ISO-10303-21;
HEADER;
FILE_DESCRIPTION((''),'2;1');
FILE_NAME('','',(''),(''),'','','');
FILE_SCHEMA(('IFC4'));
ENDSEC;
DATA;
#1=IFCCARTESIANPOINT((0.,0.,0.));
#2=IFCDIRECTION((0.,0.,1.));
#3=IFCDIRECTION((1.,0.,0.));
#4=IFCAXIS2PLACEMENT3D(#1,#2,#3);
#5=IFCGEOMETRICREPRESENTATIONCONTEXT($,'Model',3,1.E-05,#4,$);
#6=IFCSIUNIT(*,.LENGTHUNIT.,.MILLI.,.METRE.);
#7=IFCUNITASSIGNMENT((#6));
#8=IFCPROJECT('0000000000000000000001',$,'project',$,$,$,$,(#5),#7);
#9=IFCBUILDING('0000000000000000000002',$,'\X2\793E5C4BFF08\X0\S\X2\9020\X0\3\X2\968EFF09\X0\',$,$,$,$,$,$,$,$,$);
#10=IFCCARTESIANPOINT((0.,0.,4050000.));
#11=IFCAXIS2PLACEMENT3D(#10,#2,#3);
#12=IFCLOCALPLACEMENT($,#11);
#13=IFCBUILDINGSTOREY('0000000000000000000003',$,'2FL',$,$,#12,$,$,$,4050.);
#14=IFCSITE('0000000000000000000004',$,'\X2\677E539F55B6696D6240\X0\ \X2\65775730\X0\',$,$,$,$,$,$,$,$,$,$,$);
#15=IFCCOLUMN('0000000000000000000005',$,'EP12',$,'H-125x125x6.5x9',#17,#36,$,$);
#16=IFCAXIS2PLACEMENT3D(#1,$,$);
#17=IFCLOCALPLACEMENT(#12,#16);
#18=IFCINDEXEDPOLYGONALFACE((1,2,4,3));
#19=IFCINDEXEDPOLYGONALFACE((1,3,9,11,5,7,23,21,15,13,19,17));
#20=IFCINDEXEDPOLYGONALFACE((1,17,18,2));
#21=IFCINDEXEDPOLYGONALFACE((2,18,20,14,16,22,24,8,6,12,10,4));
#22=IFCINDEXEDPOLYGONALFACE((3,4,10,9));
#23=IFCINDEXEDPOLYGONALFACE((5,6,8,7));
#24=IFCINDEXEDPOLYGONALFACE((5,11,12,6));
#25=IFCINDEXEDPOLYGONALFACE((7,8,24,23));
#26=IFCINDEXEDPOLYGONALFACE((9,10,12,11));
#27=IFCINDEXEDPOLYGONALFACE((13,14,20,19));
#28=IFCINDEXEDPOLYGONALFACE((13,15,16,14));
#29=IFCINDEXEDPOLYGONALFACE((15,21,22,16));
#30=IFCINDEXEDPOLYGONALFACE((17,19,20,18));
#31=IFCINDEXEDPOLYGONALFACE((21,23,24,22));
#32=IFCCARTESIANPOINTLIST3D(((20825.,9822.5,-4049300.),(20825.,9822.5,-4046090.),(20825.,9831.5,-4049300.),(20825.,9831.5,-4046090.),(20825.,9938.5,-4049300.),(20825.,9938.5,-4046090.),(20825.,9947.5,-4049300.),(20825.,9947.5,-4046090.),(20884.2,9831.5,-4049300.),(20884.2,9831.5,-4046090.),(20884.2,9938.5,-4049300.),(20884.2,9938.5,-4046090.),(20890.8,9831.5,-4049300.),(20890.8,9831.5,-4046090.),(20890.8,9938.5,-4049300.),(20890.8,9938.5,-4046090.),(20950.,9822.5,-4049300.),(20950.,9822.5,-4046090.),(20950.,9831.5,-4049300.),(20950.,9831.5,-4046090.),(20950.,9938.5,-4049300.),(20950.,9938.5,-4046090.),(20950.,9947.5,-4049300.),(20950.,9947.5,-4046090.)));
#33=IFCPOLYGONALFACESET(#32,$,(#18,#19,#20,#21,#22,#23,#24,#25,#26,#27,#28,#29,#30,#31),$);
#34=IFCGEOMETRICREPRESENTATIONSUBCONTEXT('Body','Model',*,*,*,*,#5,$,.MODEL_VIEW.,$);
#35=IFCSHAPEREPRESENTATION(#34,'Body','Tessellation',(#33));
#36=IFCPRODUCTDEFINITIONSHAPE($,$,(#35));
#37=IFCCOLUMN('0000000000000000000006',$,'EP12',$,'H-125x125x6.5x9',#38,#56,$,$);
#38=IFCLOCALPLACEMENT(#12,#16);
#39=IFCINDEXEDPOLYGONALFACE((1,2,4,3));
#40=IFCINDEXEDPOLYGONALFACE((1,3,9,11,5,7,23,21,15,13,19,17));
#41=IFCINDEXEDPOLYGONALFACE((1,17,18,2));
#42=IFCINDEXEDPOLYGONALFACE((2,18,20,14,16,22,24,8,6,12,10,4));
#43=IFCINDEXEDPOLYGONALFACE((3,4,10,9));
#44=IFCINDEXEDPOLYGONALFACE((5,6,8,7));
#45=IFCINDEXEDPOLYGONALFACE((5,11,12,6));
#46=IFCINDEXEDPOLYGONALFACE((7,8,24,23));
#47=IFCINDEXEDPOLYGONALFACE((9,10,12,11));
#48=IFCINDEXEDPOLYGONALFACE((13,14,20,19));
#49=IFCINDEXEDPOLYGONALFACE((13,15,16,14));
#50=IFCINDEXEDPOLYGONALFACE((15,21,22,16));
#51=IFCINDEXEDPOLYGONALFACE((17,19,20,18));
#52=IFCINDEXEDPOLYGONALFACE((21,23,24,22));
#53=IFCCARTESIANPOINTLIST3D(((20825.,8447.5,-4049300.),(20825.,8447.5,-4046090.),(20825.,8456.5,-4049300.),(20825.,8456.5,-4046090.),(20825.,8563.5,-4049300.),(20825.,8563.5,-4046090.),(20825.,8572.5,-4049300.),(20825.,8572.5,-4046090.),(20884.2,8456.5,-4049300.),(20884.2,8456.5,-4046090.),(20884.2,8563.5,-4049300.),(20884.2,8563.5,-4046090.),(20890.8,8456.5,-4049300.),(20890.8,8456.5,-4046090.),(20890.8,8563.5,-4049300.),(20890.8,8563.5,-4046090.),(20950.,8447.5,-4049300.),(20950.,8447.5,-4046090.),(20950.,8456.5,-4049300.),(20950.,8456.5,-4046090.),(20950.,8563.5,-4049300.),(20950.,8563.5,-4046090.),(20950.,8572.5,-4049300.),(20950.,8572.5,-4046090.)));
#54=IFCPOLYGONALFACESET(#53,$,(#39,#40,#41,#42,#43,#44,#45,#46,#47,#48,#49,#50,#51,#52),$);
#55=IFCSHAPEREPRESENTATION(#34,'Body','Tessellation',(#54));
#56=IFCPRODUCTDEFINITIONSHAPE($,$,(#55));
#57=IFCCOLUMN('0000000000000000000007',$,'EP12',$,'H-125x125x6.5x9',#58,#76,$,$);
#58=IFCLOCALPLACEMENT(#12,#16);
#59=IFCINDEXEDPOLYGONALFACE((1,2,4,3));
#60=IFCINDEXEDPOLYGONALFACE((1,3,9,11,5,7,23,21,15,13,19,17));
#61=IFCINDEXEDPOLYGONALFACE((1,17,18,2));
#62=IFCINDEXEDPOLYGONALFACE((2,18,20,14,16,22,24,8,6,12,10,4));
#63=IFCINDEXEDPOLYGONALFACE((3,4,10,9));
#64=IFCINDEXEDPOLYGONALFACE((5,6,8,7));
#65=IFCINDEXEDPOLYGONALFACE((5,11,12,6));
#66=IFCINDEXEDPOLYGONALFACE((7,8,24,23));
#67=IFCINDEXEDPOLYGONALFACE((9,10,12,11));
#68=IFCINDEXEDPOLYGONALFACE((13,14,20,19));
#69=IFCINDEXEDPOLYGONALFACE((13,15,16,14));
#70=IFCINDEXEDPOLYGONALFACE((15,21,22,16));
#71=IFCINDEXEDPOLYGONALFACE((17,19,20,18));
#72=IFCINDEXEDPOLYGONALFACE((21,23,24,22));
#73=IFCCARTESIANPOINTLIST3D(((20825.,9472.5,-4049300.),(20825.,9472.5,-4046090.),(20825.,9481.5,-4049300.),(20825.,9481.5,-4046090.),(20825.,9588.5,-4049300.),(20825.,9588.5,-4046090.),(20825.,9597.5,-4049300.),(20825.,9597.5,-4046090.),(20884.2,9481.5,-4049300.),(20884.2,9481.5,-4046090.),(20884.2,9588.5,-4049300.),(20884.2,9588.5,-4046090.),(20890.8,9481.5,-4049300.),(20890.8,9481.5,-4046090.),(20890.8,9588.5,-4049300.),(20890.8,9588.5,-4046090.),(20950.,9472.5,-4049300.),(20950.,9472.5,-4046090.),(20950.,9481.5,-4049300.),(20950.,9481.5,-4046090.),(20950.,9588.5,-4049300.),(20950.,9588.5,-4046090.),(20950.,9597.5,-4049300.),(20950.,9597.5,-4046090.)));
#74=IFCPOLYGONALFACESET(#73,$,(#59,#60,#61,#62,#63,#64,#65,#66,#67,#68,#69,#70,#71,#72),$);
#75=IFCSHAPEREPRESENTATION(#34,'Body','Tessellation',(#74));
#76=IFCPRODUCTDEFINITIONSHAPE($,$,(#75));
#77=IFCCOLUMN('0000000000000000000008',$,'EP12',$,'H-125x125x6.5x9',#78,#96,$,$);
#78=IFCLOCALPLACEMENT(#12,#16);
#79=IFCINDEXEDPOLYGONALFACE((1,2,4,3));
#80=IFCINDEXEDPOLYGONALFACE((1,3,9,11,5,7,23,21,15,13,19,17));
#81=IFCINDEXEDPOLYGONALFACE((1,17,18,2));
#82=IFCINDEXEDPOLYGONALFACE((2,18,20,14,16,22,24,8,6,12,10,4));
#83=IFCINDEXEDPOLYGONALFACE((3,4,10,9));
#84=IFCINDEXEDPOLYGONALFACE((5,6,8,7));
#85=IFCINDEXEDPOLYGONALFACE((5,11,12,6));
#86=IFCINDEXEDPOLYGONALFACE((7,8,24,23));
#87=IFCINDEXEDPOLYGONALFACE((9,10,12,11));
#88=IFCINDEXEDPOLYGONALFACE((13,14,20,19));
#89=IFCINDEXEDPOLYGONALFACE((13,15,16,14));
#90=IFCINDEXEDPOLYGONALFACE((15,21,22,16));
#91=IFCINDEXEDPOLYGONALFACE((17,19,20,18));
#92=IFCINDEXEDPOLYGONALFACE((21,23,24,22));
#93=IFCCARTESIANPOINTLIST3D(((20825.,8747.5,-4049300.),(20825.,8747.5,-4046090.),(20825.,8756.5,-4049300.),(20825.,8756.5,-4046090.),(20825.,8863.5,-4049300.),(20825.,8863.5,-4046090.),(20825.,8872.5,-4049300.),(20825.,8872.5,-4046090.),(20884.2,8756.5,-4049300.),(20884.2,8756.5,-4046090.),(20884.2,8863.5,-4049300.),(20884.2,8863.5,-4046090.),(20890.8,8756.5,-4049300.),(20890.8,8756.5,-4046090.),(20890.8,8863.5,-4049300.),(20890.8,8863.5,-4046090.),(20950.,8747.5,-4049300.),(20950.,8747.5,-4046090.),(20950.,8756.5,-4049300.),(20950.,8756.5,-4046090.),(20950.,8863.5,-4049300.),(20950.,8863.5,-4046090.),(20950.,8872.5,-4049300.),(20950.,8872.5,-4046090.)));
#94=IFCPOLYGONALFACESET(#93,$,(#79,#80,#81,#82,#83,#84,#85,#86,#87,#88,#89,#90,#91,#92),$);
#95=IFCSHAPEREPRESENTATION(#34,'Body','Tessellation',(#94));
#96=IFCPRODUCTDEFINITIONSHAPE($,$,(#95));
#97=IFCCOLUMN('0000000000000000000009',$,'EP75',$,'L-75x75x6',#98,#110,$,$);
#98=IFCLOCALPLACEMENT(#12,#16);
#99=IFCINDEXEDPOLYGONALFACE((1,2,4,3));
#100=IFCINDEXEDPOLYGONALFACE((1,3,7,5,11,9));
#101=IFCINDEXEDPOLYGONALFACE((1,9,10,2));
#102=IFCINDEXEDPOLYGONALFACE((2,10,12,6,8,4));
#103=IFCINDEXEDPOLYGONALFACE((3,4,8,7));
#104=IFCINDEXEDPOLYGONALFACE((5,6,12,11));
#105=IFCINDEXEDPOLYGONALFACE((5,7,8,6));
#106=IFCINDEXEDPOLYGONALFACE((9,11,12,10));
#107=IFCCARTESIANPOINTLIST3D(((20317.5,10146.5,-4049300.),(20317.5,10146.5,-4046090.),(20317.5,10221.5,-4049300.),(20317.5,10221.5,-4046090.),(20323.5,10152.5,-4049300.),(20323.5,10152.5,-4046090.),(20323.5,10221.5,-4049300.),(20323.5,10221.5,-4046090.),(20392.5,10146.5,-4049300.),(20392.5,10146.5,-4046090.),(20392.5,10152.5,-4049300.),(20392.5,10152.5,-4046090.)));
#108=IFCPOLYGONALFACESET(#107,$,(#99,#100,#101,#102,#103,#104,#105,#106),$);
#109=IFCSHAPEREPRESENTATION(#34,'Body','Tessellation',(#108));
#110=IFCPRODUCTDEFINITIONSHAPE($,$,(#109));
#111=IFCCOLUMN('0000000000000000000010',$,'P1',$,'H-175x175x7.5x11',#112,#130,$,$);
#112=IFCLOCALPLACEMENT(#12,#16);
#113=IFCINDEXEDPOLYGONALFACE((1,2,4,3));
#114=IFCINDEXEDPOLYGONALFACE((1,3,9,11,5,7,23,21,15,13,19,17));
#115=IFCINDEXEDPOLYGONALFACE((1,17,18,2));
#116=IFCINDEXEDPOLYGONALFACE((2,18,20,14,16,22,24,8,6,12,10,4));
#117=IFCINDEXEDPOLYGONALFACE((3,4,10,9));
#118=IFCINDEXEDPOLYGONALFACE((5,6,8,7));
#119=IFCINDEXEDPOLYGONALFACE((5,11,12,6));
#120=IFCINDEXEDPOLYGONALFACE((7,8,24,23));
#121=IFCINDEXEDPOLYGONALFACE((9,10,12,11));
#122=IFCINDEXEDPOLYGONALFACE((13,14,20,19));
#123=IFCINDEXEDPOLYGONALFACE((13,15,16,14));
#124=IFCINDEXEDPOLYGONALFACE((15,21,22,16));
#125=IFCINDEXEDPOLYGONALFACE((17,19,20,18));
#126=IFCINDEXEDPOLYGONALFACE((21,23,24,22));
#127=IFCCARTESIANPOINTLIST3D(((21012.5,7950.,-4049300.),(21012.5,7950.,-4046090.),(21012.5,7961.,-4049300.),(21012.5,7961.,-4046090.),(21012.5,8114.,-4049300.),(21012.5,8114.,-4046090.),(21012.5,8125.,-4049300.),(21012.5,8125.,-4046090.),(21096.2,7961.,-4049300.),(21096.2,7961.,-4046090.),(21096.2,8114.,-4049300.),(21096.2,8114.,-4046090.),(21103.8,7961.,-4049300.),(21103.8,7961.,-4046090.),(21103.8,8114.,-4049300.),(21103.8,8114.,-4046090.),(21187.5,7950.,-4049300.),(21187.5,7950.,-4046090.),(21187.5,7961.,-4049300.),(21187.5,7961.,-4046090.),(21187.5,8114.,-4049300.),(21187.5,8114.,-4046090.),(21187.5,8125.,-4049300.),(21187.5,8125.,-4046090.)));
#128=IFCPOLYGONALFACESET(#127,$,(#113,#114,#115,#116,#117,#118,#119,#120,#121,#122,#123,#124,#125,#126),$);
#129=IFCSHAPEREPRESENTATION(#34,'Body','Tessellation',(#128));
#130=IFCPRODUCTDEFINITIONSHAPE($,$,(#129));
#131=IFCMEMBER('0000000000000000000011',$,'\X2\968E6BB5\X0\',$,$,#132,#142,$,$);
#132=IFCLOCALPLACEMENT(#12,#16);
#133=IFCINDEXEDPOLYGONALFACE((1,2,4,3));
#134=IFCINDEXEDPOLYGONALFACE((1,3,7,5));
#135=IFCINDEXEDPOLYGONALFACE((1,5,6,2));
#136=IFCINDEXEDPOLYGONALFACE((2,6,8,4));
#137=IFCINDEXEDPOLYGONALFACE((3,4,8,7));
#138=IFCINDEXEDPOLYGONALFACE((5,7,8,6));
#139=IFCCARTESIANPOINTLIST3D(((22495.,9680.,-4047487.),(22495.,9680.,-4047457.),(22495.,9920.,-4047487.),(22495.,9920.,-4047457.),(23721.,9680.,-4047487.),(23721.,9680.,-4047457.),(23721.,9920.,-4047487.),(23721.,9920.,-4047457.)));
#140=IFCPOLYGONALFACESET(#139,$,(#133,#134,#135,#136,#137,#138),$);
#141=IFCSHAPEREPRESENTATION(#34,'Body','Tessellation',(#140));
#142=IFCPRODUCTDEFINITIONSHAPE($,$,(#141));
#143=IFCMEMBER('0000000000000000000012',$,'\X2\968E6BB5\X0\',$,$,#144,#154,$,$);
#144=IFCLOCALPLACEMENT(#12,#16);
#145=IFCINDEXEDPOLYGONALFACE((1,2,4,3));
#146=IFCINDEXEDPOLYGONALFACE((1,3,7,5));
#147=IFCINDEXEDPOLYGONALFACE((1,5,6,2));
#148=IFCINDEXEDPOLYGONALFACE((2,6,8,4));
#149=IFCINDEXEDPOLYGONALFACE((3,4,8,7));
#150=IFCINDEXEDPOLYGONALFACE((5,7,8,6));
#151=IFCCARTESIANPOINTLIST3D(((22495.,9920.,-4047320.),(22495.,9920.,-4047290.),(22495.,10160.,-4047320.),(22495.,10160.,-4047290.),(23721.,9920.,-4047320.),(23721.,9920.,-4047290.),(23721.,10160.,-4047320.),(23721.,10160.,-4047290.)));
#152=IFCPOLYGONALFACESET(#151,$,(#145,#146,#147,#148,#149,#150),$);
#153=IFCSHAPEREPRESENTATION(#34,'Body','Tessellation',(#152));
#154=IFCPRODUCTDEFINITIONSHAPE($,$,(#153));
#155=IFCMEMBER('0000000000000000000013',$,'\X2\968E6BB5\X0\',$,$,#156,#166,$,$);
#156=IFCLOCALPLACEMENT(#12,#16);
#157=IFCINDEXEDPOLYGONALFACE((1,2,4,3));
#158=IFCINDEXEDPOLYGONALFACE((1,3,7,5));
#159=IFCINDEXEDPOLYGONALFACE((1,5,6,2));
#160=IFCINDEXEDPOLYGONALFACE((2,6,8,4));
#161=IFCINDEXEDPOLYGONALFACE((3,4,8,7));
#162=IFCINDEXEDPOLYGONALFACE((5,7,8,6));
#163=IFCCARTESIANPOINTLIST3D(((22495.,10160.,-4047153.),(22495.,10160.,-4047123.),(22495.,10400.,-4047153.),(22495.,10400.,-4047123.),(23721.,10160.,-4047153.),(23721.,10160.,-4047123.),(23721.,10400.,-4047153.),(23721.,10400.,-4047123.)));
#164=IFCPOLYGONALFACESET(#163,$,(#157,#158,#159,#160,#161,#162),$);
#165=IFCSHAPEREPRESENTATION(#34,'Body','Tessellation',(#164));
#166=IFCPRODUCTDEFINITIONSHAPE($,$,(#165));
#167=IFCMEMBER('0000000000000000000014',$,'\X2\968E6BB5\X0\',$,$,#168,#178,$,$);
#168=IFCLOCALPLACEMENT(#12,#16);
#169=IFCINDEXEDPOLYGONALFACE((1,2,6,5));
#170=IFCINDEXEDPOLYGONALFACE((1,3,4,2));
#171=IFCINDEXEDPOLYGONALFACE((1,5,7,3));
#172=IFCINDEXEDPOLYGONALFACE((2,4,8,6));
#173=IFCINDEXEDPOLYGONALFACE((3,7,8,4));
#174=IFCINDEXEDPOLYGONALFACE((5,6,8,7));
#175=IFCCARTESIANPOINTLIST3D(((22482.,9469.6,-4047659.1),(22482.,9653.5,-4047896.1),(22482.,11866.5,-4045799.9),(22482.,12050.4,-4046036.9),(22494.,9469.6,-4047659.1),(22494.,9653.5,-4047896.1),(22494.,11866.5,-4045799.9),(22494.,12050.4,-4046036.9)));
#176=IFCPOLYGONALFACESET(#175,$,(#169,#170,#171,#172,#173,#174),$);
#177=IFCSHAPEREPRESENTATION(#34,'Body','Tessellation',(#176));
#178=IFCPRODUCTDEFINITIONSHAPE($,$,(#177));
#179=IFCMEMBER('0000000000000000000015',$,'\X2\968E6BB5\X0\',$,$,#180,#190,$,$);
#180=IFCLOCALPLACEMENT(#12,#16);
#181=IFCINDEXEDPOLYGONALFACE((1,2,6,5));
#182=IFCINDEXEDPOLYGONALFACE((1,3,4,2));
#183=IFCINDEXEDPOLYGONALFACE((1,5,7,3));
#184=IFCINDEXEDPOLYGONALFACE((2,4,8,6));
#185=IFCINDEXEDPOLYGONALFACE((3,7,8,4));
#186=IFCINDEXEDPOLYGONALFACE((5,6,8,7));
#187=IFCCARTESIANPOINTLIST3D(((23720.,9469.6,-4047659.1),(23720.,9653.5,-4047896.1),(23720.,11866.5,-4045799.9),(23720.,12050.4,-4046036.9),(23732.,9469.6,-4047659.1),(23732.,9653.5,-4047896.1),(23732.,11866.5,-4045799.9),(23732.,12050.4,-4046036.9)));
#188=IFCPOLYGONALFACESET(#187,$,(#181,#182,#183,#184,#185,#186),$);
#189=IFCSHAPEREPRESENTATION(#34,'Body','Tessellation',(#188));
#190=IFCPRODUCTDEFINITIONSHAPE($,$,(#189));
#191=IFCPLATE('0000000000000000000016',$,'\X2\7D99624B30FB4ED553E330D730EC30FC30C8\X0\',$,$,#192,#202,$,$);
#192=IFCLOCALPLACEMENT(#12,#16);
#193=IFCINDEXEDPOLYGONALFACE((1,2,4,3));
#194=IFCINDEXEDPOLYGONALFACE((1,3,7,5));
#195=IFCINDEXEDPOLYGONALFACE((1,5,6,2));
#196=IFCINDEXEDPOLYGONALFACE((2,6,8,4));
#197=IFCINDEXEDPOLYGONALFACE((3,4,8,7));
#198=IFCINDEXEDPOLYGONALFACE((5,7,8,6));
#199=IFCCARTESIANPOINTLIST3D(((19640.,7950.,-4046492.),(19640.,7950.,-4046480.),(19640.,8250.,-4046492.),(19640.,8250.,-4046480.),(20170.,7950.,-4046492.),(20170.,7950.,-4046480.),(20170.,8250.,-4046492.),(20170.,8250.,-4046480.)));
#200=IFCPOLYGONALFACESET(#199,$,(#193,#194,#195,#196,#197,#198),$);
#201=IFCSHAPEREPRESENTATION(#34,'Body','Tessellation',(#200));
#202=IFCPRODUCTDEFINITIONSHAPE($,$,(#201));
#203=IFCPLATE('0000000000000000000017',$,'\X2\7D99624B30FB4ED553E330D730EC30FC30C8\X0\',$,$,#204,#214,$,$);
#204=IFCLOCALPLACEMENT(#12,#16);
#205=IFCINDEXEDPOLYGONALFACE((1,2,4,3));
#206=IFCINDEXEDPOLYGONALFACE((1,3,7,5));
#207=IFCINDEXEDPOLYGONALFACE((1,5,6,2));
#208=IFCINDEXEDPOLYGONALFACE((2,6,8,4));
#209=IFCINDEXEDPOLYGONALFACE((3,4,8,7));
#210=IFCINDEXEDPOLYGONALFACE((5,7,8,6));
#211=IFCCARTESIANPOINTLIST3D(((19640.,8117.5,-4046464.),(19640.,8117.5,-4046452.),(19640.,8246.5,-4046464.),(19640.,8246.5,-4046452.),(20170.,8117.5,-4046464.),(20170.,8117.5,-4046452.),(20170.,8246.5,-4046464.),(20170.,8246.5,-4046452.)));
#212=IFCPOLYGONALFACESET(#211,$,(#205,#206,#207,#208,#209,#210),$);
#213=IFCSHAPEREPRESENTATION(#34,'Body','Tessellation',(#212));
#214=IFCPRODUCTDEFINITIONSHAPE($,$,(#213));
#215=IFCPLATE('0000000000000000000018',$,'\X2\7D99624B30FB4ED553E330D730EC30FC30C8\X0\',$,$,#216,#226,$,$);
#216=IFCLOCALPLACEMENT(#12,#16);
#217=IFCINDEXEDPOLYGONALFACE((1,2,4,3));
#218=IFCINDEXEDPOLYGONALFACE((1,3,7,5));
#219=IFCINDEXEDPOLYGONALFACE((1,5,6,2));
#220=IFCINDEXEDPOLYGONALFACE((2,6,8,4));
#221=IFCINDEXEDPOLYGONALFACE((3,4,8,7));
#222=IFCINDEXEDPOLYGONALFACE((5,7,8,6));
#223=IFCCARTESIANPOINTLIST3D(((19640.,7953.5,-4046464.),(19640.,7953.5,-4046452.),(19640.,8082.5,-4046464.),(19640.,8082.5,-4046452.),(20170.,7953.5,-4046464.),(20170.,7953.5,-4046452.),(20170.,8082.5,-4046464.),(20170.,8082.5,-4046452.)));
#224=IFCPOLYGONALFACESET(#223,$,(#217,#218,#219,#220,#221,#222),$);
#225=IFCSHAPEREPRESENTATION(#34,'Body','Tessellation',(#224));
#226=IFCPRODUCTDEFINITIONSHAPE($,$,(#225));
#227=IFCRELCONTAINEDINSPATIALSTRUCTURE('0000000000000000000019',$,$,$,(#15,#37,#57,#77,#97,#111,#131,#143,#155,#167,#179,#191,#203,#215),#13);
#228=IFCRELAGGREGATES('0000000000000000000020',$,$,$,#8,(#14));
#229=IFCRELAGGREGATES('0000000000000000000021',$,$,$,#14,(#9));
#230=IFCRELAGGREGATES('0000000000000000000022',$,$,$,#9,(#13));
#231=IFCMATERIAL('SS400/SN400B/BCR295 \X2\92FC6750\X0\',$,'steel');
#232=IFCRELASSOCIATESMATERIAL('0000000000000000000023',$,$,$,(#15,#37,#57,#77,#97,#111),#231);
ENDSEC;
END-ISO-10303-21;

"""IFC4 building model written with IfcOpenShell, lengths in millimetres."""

from ifc_helpers import new_model, si_unit, frame, origin, origin_with_axes, place, context, subcontext, project, spatial, rectangle, i_section, l_section, extrude, material, element, save


model = new_model("IFC4")

# Units and contexts
model_context = context("Model", 3, precision=1e-05, world=origin_with_axes())
body_context = subcontext(model_context, "Body", "Model", "MODEL_VIEW")
ifc_project = project(units=[si_unit("LENGTHUNIT", "METRE", prefix="MILLI")], contexts=[model_context])

# Site, building, storey
site = spatial("IfcSite", under=ifc_project, Name="松原営業所 敷地")
building = spatial("IfcBuilding", under=site, Name="社屋（S造3階）")
storey_placement = place(None, frame((0.0, 0.0, 4050000.0), z_axis=(0.0, 0.0, 1.0), x_axis=(1.0, 0.0, 0.0)))
storey = spatial("IfcBuildingStorey", under=building, at=storey_placement, Name="2FL", Elevation=4050.0)

# Columns
ifc_material = material(Name="SS400/SN400B/BCR295 鋼材", Category="steel")
for number, where, z_axis, x_axis, name in (
    (1, (20887.5, 9885.0, -4049300.0), (0.0, 0.0, 1.0), (1.0, 0.0, 0.0), "EP12"),
    (2, (20887.5, 8510.0, -4049300.0), (0.0, 0.0, 1.0), (1.0, 0.0, 0.0), "EP12"),
    (3, (20887.5, 9535.0, -4049300.0), (0.0, 0.0, 1.0), (1.0, 0.0, 0.0), "EP12"),
    (4, (20887.5, 8810.0, -4049300.0), (0.0, 0.0, 1.0), (1.0, 0.0, 0.0), "EP12"),
):
    element("IfcColumn", number, at=place(storey_placement, frame(where, z_axis=z_axis, x_axis=x_axis)), inside=storey, material=ifc_material, Name=name, ObjectType="H-125x125x6.5x9", context=body_context, shape_type="SweptSolid", body=[
        extrude(i_section(OverallWidth=125.0, OverallDepth=125.0, WebThickness=6.5, FlangeThickness=9.0), origin(), (0.0, 0.0, 1.0), 3210.0),
    ])
column_1_placement = place(storey_placement, frame((20355.0, 10184.0, -4049300.0), z_axis=(0.0, 0.0, 1.0), x_axis=(1.0, 0.0, 0.0)))
element("IfcColumn", 5, at=column_1_placement, inside=storey, material=ifc_material, Name="EP75", ObjectType="L-75x75x6", context=body_context, shape_type="SweptSolid", body=[
    extrude(l_section(Depth=75.0, Width=75.0, Thickness=6.0), origin(), (0.0, 0.0, 1.0), 3210.0),
])
column_2_placement = place(storey_placement, frame((21100.0, 8037.5, -4049300.0), z_axis=(0.0, 0.0, 1.0), x_axis=(1.0, 0.0, 0.0)))
element("IfcColumn", 6, at=column_2_placement, inside=storey, material=ifc_material, Name="P1", ObjectType="H-175x175x7.5x11", context=body_context, shape_type="SweptSolid", body=[
    extrude(i_section(OverallWidth=175.0, OverallDepth=175.0, WebThickness=7.5, FlangeThickness=11.0), origin(), (0.0, 0.0, 1.0), 3210.0),
])

# Members
for number, where, z_axis, x_axis, name in (
    (7, (23108.0, 9680.0, -4047472.0), (0.0, 1.0, 0.0), (-1.0, 0.0, 0.0), "階段"),
    (8, (23108.0, 9920.0, -4047305.0), (0.0, 1.0, 0.0), (-1.0, 0.0, 0.0), "階段"),
    (9, (23108.0, 10160.0, -4047138.0), (0.0, 1.0, 0.0), (-1.0, 0.0, 0.0), "階段"),
):
    element("IfcMember", number, at=place(storey_placement, frame(where, z_axis=z_axis, x_axis=x_axis)), inside=storey, Name=name, context=body_context, shape_type="SweptSolid", body=[
        extrude(rectangle(XDim=1226.0, YDim=30.0), origin(), (0.0, 0.0, 1.0), 240.0),
    ])
for number, where, z_axis, x_axis, name in (
    (10, (22488.0, 9561.6, -4047777.6), (0.0, 0.790155, 0.612907), (-1.0, 0.0, 0.0), "階段"),
    (11, (23726.0, 9561.6, -4047777.6), (0.0, 0.790155, 0.612907), (-1.0, 0.0, 0.0), "階段"),
):
    element("IfcMember", number, at=place(storey_placement, frame(where, z_axis=z_axis, x_axis=x_axis)), inside=storey, Name=name, context=body_context, shape_type="SweptSolid", body=[
        extrude(rectangle(XDim=12.0, YDim=300.0), origin(), (0.0, 0.0, 1.0), 3033.4),
    ])

# Plates
plate_1_placement = place(storey_placement, frame((19640.0, 8100.0, -4046486.0), z_axis=(1.0, 0.0, 0.0), x_axis=(0.0, 1.0, 0.0)))
element("IfcPlate", 12, at=plate_1_placement, inside=storey, Name="継手・仕口プレート", context=body_context, shape_type="SweptSolid", body=[
    extrude(rectangle(XDim=300.0, YDim=12.0), origin(), (0.0, 0.0, 1.0), 530.0),
])
for number, where, z_axis, x_axis, name in (
    (13, (19640.0, 8182.0, -4046458.0), (1.0, 0.0, 0.0), (0.0, 1.0, 0.0), "継手・仕口プレート"),
    (14, (19640.0, 8018.0, -4046458.0), (1.0, 0.0, 0.0), (0.0, 1.0, 0.0), "継手・仕口プレート"),
):
    element("IfcPlate", number, at=place(storey_placement, frame(where, z_axis=z_axis, x_axis=x_axis)), inside=storey, Name=name, context=body_context, shape_type="SweptSolid", body=[
        extrude(rectangle(XDim=129.0, YDim=12.0), origin(), (0.0, 0.0, 1.0), 530.0),
    ])

save(model, "model.ifc")
